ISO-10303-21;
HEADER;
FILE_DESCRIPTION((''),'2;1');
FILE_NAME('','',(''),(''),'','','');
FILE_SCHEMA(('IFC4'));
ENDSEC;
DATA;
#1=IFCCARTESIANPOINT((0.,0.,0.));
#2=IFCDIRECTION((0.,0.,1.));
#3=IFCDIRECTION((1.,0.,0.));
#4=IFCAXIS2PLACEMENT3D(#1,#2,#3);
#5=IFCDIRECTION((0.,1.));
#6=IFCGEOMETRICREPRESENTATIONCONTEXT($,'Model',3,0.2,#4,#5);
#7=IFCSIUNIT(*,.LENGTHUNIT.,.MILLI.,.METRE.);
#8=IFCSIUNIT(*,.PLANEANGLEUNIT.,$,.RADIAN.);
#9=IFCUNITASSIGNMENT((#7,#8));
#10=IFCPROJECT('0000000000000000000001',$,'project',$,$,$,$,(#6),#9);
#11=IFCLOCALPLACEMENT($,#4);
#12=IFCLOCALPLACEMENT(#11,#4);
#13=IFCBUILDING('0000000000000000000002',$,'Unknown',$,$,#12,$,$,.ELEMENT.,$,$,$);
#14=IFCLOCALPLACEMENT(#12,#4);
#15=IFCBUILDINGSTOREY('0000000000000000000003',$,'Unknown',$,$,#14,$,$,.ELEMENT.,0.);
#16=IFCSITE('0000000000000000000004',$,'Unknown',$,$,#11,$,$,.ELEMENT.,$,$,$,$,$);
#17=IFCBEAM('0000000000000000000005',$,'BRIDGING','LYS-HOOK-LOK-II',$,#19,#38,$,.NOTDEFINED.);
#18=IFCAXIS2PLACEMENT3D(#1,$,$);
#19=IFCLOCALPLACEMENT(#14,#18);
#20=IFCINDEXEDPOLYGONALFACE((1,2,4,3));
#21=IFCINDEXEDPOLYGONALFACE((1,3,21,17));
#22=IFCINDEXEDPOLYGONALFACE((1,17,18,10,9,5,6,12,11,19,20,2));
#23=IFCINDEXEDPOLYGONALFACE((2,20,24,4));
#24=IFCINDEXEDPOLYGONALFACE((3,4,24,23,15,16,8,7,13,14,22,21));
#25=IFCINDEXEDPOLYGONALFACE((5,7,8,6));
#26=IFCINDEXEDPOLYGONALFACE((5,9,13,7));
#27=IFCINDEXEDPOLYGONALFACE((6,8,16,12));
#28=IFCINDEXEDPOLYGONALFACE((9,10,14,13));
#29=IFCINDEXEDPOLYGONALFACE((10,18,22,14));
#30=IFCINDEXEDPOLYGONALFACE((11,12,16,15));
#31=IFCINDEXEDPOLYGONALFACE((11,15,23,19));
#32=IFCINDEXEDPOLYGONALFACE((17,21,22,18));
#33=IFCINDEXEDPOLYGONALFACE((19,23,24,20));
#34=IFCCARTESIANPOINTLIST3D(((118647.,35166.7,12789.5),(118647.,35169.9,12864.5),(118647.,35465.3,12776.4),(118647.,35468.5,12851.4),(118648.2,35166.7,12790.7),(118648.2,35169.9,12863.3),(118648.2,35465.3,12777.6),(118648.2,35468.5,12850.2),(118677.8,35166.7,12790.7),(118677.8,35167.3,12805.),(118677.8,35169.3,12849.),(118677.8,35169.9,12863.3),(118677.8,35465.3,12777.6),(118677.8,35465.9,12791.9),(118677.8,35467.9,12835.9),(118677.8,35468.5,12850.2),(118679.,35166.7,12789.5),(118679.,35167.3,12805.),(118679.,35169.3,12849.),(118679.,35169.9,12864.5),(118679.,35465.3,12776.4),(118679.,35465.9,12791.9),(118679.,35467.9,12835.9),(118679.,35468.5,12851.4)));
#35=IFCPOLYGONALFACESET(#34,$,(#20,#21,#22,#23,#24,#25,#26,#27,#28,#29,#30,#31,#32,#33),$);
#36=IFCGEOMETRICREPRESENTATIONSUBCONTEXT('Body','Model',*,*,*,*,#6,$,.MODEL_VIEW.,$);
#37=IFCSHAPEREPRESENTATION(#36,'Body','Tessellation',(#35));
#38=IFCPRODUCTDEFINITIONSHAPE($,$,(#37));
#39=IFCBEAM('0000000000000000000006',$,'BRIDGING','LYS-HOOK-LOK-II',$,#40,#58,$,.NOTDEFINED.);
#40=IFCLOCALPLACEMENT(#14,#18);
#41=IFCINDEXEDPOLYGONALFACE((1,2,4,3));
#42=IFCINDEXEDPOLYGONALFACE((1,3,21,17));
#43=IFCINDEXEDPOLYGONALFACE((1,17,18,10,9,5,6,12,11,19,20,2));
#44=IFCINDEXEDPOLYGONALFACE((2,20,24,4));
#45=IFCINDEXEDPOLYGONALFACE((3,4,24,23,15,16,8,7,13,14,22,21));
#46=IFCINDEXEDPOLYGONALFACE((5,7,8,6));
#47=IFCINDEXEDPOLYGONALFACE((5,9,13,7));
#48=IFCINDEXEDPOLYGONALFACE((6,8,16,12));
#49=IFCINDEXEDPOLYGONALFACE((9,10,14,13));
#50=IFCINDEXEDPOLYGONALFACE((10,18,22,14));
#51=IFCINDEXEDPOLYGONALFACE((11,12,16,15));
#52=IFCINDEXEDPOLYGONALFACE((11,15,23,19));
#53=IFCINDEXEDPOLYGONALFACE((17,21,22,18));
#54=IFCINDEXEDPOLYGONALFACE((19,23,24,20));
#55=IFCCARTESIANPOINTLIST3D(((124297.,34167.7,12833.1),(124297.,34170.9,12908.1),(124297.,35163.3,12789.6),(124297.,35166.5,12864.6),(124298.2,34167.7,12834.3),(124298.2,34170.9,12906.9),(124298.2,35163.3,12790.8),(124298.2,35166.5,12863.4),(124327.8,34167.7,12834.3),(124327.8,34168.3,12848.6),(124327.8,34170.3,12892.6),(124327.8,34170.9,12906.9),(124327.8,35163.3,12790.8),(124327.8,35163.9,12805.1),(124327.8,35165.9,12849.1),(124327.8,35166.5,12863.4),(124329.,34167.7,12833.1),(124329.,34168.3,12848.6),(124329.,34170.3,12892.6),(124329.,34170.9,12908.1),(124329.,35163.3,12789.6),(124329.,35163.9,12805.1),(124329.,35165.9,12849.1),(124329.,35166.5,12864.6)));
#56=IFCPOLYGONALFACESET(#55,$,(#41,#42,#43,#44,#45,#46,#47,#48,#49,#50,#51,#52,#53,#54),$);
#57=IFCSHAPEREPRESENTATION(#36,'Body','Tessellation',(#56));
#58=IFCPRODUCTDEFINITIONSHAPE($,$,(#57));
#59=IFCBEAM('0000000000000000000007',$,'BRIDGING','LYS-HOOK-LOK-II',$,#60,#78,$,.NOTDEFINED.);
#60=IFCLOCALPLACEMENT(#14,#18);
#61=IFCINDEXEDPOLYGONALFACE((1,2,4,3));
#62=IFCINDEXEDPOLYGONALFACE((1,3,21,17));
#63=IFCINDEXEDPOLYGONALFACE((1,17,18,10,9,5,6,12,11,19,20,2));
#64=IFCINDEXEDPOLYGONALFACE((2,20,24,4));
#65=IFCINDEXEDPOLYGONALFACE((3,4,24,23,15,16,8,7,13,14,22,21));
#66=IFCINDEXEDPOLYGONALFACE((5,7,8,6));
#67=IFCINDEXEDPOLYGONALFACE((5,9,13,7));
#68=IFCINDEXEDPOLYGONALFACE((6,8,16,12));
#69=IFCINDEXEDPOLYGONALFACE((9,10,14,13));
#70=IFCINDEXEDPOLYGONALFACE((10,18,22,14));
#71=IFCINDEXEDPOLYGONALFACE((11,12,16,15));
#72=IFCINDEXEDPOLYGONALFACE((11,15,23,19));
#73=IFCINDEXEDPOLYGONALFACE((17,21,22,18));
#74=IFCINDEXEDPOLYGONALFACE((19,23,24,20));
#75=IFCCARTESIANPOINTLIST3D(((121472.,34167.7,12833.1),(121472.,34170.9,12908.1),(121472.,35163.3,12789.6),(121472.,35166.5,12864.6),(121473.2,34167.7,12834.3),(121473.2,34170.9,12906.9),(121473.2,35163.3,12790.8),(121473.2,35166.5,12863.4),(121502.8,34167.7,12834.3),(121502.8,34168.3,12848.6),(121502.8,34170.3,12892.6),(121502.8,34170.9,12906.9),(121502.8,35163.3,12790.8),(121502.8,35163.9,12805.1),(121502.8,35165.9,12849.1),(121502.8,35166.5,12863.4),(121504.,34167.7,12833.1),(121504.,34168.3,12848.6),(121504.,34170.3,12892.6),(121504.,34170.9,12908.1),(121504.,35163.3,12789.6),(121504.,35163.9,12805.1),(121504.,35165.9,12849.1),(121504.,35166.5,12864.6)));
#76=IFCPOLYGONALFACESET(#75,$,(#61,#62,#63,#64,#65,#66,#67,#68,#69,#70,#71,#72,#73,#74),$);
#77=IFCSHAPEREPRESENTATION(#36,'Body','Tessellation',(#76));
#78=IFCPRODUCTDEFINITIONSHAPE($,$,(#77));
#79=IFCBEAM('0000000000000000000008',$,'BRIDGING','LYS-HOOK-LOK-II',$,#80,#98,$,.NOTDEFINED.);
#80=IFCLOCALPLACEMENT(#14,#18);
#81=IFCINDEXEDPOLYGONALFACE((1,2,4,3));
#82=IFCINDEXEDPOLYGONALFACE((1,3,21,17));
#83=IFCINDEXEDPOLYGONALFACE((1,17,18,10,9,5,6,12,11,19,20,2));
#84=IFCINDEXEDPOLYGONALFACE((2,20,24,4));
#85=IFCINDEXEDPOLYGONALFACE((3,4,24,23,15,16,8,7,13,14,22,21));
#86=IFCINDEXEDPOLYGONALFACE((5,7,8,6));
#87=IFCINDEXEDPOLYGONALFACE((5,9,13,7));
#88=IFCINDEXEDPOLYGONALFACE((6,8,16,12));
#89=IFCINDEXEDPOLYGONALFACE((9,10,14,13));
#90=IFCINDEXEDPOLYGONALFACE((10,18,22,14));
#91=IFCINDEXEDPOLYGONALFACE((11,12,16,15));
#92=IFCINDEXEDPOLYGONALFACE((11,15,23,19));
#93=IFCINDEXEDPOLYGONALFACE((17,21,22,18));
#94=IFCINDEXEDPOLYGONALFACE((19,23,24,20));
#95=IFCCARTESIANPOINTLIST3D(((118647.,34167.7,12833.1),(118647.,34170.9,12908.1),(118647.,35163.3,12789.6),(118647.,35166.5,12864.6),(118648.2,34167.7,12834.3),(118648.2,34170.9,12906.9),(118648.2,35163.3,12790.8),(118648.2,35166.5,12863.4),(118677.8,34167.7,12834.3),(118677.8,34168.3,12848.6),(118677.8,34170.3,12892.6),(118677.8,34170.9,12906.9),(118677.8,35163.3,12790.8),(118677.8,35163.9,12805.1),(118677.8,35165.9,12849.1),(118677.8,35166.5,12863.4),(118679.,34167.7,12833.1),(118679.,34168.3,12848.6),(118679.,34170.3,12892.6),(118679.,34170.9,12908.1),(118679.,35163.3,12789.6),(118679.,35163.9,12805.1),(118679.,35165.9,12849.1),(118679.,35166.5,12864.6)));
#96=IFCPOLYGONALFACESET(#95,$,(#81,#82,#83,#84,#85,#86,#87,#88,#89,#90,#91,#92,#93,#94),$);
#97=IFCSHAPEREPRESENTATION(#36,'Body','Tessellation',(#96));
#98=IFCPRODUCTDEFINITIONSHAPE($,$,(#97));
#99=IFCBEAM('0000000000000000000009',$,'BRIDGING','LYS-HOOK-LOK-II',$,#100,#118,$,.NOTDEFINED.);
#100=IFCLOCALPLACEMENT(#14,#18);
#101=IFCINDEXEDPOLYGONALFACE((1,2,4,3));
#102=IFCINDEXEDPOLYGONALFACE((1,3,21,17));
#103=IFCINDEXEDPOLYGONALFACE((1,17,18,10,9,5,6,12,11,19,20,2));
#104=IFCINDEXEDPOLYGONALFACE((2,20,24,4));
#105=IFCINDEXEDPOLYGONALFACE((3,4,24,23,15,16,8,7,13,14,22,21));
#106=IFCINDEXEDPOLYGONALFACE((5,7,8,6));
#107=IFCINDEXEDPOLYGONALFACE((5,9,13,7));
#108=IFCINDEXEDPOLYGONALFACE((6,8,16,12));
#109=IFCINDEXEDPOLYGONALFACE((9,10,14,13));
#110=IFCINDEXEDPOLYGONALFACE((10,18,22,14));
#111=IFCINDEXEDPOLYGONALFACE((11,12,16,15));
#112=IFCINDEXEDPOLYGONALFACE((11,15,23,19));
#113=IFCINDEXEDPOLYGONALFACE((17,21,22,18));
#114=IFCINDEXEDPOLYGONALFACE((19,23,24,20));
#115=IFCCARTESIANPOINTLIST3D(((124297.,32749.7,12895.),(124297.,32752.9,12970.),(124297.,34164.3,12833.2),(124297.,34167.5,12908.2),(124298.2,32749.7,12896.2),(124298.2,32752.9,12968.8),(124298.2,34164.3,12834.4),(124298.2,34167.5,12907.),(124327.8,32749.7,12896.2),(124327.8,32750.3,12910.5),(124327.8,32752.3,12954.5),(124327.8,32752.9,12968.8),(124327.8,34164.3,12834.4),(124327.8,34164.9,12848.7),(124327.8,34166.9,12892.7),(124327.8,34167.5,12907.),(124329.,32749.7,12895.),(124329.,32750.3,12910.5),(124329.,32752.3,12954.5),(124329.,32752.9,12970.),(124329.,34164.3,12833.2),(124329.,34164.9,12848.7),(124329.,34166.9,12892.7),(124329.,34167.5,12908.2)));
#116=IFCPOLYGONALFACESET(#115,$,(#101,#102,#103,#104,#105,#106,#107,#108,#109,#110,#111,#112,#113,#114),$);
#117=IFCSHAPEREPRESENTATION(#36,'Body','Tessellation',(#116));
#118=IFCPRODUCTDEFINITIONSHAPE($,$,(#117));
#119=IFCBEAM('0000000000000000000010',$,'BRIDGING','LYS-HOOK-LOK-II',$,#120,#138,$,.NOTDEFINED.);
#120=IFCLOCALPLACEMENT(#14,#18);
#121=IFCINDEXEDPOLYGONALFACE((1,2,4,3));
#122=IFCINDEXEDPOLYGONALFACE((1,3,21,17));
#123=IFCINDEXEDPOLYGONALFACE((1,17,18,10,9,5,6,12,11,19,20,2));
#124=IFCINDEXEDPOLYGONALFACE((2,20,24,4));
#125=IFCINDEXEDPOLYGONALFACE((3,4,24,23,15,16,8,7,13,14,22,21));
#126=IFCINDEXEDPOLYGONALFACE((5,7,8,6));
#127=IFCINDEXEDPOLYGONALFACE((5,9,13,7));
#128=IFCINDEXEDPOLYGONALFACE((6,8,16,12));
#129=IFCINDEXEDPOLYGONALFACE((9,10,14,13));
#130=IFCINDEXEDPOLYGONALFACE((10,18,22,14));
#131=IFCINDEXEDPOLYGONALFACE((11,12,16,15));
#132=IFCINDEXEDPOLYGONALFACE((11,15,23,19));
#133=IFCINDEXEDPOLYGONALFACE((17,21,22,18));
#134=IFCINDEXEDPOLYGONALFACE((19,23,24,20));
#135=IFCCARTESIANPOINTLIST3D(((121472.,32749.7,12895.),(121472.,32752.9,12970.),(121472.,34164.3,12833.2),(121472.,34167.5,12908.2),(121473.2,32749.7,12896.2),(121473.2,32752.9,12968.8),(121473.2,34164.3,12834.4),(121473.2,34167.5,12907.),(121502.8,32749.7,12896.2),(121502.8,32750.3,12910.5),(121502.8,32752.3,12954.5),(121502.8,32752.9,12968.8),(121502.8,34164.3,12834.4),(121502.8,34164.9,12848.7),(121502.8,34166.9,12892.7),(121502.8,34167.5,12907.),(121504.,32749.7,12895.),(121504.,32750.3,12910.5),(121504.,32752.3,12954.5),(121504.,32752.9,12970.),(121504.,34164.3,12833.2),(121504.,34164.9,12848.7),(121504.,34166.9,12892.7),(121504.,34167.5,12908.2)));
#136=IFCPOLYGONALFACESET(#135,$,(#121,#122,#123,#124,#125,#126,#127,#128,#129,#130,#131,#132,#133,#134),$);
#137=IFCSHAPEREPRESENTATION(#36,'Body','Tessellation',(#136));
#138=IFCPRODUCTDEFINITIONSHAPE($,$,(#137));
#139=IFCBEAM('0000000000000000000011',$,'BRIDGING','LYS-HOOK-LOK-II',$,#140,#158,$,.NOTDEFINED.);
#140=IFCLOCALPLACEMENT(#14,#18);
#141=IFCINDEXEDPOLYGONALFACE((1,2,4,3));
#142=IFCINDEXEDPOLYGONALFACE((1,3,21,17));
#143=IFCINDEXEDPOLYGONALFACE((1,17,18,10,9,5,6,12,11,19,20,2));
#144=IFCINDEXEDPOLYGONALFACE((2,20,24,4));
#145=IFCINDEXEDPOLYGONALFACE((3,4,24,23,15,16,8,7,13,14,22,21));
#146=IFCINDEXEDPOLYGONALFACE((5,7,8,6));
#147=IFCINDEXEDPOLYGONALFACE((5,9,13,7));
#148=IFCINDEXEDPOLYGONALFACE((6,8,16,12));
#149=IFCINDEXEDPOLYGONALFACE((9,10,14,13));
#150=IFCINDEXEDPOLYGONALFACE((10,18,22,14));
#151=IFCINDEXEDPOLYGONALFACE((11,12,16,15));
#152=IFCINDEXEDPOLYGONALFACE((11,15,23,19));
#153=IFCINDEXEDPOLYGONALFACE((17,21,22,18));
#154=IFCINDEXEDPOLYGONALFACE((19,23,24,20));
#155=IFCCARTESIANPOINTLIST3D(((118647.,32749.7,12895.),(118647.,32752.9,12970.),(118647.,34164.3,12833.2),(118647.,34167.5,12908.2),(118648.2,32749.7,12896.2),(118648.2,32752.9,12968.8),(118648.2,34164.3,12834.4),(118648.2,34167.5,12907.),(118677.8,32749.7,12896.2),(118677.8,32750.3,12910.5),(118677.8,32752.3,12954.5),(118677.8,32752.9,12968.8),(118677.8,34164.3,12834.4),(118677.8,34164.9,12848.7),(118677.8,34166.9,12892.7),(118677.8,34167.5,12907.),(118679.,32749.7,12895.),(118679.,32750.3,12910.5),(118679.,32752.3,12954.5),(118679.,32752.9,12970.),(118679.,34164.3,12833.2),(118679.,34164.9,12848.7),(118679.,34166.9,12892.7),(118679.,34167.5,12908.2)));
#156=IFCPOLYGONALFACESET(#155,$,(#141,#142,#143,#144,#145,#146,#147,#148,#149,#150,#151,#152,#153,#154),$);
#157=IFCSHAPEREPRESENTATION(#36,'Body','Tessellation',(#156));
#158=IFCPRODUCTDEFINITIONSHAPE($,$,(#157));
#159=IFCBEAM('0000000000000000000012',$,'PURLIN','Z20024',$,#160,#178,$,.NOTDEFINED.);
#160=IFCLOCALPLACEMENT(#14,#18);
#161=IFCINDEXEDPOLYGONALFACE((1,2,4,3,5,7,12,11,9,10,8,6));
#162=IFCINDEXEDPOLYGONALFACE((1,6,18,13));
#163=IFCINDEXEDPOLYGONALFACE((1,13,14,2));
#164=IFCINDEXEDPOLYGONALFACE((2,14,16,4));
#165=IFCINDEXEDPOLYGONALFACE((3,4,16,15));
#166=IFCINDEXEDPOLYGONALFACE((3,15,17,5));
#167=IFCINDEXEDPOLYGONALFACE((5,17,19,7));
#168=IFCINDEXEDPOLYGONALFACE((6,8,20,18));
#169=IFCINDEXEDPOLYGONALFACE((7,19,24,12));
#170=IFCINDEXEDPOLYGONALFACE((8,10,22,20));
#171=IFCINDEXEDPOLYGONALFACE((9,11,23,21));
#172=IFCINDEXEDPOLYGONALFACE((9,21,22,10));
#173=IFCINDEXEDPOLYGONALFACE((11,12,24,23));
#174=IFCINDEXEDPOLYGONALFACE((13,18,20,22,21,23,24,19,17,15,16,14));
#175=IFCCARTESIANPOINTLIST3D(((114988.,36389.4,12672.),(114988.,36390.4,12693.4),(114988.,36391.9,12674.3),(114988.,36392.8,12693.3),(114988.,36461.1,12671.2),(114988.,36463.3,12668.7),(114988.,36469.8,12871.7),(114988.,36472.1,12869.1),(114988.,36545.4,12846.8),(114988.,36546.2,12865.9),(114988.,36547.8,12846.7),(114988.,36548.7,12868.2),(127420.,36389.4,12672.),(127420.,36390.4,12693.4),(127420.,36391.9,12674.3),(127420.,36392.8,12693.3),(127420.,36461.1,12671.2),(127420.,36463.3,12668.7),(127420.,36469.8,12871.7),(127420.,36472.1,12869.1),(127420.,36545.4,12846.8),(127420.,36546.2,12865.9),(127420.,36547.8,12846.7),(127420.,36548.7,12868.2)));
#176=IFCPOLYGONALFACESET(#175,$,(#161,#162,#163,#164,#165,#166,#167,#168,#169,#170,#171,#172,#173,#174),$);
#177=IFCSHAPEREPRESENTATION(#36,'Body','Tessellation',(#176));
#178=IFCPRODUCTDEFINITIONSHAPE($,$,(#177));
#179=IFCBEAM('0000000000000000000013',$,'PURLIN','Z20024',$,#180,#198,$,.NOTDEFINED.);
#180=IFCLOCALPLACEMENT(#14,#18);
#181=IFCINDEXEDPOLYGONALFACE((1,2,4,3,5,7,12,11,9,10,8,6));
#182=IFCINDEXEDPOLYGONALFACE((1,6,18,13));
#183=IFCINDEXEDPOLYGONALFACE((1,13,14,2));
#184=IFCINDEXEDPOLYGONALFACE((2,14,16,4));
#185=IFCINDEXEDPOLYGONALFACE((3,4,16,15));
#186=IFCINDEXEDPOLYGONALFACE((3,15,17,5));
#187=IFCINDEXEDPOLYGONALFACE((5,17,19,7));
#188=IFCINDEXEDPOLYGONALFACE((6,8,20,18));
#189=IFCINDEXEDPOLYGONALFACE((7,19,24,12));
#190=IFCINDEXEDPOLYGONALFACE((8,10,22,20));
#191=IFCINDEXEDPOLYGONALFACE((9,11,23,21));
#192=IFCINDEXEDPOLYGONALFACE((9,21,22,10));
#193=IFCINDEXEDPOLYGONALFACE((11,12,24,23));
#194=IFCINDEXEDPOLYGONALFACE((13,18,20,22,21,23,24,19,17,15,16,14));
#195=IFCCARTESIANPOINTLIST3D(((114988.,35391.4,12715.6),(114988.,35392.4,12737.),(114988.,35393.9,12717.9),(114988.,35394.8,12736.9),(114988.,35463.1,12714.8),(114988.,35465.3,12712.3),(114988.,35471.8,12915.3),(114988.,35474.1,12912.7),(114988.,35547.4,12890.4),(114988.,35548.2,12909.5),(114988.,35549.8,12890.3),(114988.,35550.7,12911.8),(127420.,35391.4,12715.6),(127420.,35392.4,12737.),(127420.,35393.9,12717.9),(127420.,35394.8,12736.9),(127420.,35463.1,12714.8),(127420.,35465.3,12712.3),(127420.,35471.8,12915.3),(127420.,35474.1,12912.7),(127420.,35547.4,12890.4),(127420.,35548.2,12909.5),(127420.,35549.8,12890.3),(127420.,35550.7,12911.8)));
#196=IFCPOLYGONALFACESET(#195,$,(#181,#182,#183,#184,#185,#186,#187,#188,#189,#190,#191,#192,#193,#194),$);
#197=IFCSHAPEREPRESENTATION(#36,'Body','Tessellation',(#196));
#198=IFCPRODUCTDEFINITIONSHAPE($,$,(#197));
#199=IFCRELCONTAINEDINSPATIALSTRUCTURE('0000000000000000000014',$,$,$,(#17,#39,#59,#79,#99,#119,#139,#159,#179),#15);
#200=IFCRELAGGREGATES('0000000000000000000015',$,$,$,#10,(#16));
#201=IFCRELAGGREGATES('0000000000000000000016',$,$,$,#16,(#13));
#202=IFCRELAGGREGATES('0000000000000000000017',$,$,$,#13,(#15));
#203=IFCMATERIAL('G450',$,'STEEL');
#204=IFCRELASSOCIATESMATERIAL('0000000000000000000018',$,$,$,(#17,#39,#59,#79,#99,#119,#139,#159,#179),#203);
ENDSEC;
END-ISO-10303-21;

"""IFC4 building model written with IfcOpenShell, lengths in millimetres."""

from ifc_helpers import new_model, si_unit, direction, frame, origin_with_axes, place, context, subcontext, project, spatial, line, indexed_curve, outline, extrude, material, element, save


model = new_model("IFC4")

# Units and contexts
model_context = context("Model", 3, precision=0.2, world=origin_with_axes(), true_north=direction((0.0, 1.0)))
body_context = subcontext(model_context, "Body", "Model", "MODEL_VIEW")
ifc_project = project(units=[si_unit("LENGTHUNIT", "METRE", prefix="MILLI"), si_unit("PLANEANGLEUNIT", "RADIAN")], contexts=[model_context])

# Site, building, storey
site_placement = place(None, origin_with_axes())
site = spatial("IfcSite", under=ifc_project, at=site_placement, Name="Unknown", CompositionType="ELEMENT")
building_placement = place(site_placement, origin_with_axes())
building = spatial("IfcBuilding", under=site, at=building_placement, Name="Unknown", CompositionType="ELEMENT")
storey_placement = place(building_placement, origin_with_axes())
storey = spatial("IfcBuildingStorey", under=building, at=storey_placement, Name="Unknown", CompositionType="ELEMENT", Elevation=0.0)

# Beams
ifc_material_1 = material(Name="G450", Category="STEEL")
for number, where, z_axis, x_axis, name in (
    (1, (118663.0, 35168.3, 12827.0), (1.0, 0.0, 0.0), (0.0, 0.999039, -0.043829), "BRIDGING"),
):
    element("IfcBeam", number, at=place(storey_placement, frame(where, z_axis=z_axis, x_axis=x_axis)), inside=storey, material=ifc_material_1, Name=name, Description="LYS-HOOK-LOK-II", PredefinedType="NOTDEFINED", context=body_context, shape_type="SolidModel", body=[
        extrude(outline(indexed_curve([(16.0, -37.5), (16.0, -22.0), (14.8, -22.0), (14.8, -36.3), (-14.8, -36.3), (-14.8, 36.3), (14.8, 36.3), (14.8, 22.0), (16.0, 22.0), (16.0, 37.5), (-16.0, 37.5), (-16.0, -37.5)], segments=[line(1, 2, 3, 4, 5, 6, 7, 8, 9, 10, 11, 12, 1)])), frame((0.0, 0.0, 0.0), z_axis=(-1.0, 0.0, 0.0), x_axis=(0.0, 0.0, 1.0)), (0.0, 0.0, -1.0), 298.9),
    ])
for number, where, z_axis, x_axis, name in (
    (2, (124313.0, 34169.3, 12870.6), (1.0, 0.0, 0.0), (0.0, 0.999047, -0.043651), "BRIDGING"),
    (3, (121488.0, 34169.3, 12870.6), (1.0, 0.0, 0.0), (0.0, 0.999047, -0.043651), "BRIDGING"),
    (4, (118663.0, 34169.3, 12870.6), (1.0, 0.0, 0.0), (0.0, 0.999047, -0.043651), "BRIDGING"),
):
    element("IfcBeam", number, at=place(storey_placement, frame(where, z_axis=z_axis, x_axis=x_axis)), inside=storey, material=ifc_material_1, Name=name, Description="LYS-HOOK-LOK-II", PredefinedType="NOTDEFINED", context=body_context, shape_type="SolidModel", body=[
        extrude(outline(indexed_curve([(16.0, -37.5), (16.0, -22.0), (14.8, -22.0), (14.8, -36.3), (-14.8, -36.3), (-14.8, 36.3), (14.8, 36.3), (14.8, 22.0), (16.0, 22.0), (16.0, 37.5), (-16.0, 37.5), (-16.0, -37.5)], segments=[line(1, 2, 3, 4, 5, 6, 7, 8, 9, 10, 11, 12, 1)])), frame((0.0, 0.0, 0.0), z_axis=(-1.0, 0.0, 0.0), x_axis=(0.0, 0.0, 1.0)), (0.0, 0.0, -1.0), 996.5),
    ])
for number, where, z_axis, x_axis, name in (
    (5, (124313.0, 32751.3, 12932.5), (1.0, 0.0, 0.0), (0.0, 0.999047, -0.043646), "BRIDGING"),
    (6, (121488.0, 32751.3, 12932.5), (1.0, 0.0, 0.0), (0.0, 0.999047, -0.043646), "BRIDGING"),
    (7, (118663.0, 32751.3, 12932.5), (1.0, 0.0, 0.0), (0.0, 0.999047, -0.043646), "BRIDGING"),
):
    element("IfcBeam", number, at=place(storey_placement, frame(where, z_axis=z_axis, x_axis=x_axis)), inside=storey, material=ifc_material_1, Name=name, Description="LYS-HOOK-LOK-II", PredefinedType="NOTDEFINED", context=body_context, shape_type="SolidModel", body=[
        extrude(outline(indexed_curve([(16.0, -37.5), (16.0, -22.0), (14.8, -22.0), (14.8, -36.3), (-14.8, -36.3), (-14.8, 36.3), (14.8, 36.3), (14.8, 22.0), (16.0, 22.0), (16.0, 37.5), (-16.0, 37.5), (-16.0, -37.5)], segments=[line(1, 2, 3, 4, 5, 6, 7, 8, 9, 10, 11, 12, 1)])), frame((0.0, 0.0, 0.0), z_axis=(-1.0, 0.0, 0.0), x_axis=(0.0, 0.0, 1.0)), (0.0, 0.0, -1.0), 1415.9),
    ])
for number, where, z_axis, x_axis, name in (
    (8, (114988.0, 36466.6, 12770.2), (0.0, -0.999048, 0.043619), (1.0, 0.0, 0.0), "PURLIN"),
    (9, (114988.0, 35468.6, 12813.8), (0.0, -0.999048, 0.043619), (1.0, 0.0, 0.0), "PURLIN"),
):
    element("IfcBeam", number, at=place(storey_placement, frame(where, z_axis=z_axis, x_axis=x_axis)), inside=storey, material=ifc_material_1, Name=name, Description="Z20024", PredefinedType="NOTDEFINED", context=body_context, shape_type="SolidModel", body=[
        extrude(outline(indexed_curve([(72.8, -101.5), (72.8, -80.0), (70.4, -80.0), (70.4, -99.1), (1.2, -99.1), (1.2, 101.5), (-77.8, 101.5), (-77.8, 80.0), (-75.4, 80.0), (-75.4, 99.1), (-1.2, 99.1), (-1.2, -101.5)], segments=[line(1, 2, 3, 4, 5, 6, 7, 8, 9, 10, 11, 12, 1)])), frame((0.0, 0.0, 0.0), z_axis=(-1.0, 0.0, 0.0), x_axis=(0.0, 0.0, 1.0)), (0.0, 0.0, -1.0), 12432.0),
    ])

save(model, "model.ifc")
